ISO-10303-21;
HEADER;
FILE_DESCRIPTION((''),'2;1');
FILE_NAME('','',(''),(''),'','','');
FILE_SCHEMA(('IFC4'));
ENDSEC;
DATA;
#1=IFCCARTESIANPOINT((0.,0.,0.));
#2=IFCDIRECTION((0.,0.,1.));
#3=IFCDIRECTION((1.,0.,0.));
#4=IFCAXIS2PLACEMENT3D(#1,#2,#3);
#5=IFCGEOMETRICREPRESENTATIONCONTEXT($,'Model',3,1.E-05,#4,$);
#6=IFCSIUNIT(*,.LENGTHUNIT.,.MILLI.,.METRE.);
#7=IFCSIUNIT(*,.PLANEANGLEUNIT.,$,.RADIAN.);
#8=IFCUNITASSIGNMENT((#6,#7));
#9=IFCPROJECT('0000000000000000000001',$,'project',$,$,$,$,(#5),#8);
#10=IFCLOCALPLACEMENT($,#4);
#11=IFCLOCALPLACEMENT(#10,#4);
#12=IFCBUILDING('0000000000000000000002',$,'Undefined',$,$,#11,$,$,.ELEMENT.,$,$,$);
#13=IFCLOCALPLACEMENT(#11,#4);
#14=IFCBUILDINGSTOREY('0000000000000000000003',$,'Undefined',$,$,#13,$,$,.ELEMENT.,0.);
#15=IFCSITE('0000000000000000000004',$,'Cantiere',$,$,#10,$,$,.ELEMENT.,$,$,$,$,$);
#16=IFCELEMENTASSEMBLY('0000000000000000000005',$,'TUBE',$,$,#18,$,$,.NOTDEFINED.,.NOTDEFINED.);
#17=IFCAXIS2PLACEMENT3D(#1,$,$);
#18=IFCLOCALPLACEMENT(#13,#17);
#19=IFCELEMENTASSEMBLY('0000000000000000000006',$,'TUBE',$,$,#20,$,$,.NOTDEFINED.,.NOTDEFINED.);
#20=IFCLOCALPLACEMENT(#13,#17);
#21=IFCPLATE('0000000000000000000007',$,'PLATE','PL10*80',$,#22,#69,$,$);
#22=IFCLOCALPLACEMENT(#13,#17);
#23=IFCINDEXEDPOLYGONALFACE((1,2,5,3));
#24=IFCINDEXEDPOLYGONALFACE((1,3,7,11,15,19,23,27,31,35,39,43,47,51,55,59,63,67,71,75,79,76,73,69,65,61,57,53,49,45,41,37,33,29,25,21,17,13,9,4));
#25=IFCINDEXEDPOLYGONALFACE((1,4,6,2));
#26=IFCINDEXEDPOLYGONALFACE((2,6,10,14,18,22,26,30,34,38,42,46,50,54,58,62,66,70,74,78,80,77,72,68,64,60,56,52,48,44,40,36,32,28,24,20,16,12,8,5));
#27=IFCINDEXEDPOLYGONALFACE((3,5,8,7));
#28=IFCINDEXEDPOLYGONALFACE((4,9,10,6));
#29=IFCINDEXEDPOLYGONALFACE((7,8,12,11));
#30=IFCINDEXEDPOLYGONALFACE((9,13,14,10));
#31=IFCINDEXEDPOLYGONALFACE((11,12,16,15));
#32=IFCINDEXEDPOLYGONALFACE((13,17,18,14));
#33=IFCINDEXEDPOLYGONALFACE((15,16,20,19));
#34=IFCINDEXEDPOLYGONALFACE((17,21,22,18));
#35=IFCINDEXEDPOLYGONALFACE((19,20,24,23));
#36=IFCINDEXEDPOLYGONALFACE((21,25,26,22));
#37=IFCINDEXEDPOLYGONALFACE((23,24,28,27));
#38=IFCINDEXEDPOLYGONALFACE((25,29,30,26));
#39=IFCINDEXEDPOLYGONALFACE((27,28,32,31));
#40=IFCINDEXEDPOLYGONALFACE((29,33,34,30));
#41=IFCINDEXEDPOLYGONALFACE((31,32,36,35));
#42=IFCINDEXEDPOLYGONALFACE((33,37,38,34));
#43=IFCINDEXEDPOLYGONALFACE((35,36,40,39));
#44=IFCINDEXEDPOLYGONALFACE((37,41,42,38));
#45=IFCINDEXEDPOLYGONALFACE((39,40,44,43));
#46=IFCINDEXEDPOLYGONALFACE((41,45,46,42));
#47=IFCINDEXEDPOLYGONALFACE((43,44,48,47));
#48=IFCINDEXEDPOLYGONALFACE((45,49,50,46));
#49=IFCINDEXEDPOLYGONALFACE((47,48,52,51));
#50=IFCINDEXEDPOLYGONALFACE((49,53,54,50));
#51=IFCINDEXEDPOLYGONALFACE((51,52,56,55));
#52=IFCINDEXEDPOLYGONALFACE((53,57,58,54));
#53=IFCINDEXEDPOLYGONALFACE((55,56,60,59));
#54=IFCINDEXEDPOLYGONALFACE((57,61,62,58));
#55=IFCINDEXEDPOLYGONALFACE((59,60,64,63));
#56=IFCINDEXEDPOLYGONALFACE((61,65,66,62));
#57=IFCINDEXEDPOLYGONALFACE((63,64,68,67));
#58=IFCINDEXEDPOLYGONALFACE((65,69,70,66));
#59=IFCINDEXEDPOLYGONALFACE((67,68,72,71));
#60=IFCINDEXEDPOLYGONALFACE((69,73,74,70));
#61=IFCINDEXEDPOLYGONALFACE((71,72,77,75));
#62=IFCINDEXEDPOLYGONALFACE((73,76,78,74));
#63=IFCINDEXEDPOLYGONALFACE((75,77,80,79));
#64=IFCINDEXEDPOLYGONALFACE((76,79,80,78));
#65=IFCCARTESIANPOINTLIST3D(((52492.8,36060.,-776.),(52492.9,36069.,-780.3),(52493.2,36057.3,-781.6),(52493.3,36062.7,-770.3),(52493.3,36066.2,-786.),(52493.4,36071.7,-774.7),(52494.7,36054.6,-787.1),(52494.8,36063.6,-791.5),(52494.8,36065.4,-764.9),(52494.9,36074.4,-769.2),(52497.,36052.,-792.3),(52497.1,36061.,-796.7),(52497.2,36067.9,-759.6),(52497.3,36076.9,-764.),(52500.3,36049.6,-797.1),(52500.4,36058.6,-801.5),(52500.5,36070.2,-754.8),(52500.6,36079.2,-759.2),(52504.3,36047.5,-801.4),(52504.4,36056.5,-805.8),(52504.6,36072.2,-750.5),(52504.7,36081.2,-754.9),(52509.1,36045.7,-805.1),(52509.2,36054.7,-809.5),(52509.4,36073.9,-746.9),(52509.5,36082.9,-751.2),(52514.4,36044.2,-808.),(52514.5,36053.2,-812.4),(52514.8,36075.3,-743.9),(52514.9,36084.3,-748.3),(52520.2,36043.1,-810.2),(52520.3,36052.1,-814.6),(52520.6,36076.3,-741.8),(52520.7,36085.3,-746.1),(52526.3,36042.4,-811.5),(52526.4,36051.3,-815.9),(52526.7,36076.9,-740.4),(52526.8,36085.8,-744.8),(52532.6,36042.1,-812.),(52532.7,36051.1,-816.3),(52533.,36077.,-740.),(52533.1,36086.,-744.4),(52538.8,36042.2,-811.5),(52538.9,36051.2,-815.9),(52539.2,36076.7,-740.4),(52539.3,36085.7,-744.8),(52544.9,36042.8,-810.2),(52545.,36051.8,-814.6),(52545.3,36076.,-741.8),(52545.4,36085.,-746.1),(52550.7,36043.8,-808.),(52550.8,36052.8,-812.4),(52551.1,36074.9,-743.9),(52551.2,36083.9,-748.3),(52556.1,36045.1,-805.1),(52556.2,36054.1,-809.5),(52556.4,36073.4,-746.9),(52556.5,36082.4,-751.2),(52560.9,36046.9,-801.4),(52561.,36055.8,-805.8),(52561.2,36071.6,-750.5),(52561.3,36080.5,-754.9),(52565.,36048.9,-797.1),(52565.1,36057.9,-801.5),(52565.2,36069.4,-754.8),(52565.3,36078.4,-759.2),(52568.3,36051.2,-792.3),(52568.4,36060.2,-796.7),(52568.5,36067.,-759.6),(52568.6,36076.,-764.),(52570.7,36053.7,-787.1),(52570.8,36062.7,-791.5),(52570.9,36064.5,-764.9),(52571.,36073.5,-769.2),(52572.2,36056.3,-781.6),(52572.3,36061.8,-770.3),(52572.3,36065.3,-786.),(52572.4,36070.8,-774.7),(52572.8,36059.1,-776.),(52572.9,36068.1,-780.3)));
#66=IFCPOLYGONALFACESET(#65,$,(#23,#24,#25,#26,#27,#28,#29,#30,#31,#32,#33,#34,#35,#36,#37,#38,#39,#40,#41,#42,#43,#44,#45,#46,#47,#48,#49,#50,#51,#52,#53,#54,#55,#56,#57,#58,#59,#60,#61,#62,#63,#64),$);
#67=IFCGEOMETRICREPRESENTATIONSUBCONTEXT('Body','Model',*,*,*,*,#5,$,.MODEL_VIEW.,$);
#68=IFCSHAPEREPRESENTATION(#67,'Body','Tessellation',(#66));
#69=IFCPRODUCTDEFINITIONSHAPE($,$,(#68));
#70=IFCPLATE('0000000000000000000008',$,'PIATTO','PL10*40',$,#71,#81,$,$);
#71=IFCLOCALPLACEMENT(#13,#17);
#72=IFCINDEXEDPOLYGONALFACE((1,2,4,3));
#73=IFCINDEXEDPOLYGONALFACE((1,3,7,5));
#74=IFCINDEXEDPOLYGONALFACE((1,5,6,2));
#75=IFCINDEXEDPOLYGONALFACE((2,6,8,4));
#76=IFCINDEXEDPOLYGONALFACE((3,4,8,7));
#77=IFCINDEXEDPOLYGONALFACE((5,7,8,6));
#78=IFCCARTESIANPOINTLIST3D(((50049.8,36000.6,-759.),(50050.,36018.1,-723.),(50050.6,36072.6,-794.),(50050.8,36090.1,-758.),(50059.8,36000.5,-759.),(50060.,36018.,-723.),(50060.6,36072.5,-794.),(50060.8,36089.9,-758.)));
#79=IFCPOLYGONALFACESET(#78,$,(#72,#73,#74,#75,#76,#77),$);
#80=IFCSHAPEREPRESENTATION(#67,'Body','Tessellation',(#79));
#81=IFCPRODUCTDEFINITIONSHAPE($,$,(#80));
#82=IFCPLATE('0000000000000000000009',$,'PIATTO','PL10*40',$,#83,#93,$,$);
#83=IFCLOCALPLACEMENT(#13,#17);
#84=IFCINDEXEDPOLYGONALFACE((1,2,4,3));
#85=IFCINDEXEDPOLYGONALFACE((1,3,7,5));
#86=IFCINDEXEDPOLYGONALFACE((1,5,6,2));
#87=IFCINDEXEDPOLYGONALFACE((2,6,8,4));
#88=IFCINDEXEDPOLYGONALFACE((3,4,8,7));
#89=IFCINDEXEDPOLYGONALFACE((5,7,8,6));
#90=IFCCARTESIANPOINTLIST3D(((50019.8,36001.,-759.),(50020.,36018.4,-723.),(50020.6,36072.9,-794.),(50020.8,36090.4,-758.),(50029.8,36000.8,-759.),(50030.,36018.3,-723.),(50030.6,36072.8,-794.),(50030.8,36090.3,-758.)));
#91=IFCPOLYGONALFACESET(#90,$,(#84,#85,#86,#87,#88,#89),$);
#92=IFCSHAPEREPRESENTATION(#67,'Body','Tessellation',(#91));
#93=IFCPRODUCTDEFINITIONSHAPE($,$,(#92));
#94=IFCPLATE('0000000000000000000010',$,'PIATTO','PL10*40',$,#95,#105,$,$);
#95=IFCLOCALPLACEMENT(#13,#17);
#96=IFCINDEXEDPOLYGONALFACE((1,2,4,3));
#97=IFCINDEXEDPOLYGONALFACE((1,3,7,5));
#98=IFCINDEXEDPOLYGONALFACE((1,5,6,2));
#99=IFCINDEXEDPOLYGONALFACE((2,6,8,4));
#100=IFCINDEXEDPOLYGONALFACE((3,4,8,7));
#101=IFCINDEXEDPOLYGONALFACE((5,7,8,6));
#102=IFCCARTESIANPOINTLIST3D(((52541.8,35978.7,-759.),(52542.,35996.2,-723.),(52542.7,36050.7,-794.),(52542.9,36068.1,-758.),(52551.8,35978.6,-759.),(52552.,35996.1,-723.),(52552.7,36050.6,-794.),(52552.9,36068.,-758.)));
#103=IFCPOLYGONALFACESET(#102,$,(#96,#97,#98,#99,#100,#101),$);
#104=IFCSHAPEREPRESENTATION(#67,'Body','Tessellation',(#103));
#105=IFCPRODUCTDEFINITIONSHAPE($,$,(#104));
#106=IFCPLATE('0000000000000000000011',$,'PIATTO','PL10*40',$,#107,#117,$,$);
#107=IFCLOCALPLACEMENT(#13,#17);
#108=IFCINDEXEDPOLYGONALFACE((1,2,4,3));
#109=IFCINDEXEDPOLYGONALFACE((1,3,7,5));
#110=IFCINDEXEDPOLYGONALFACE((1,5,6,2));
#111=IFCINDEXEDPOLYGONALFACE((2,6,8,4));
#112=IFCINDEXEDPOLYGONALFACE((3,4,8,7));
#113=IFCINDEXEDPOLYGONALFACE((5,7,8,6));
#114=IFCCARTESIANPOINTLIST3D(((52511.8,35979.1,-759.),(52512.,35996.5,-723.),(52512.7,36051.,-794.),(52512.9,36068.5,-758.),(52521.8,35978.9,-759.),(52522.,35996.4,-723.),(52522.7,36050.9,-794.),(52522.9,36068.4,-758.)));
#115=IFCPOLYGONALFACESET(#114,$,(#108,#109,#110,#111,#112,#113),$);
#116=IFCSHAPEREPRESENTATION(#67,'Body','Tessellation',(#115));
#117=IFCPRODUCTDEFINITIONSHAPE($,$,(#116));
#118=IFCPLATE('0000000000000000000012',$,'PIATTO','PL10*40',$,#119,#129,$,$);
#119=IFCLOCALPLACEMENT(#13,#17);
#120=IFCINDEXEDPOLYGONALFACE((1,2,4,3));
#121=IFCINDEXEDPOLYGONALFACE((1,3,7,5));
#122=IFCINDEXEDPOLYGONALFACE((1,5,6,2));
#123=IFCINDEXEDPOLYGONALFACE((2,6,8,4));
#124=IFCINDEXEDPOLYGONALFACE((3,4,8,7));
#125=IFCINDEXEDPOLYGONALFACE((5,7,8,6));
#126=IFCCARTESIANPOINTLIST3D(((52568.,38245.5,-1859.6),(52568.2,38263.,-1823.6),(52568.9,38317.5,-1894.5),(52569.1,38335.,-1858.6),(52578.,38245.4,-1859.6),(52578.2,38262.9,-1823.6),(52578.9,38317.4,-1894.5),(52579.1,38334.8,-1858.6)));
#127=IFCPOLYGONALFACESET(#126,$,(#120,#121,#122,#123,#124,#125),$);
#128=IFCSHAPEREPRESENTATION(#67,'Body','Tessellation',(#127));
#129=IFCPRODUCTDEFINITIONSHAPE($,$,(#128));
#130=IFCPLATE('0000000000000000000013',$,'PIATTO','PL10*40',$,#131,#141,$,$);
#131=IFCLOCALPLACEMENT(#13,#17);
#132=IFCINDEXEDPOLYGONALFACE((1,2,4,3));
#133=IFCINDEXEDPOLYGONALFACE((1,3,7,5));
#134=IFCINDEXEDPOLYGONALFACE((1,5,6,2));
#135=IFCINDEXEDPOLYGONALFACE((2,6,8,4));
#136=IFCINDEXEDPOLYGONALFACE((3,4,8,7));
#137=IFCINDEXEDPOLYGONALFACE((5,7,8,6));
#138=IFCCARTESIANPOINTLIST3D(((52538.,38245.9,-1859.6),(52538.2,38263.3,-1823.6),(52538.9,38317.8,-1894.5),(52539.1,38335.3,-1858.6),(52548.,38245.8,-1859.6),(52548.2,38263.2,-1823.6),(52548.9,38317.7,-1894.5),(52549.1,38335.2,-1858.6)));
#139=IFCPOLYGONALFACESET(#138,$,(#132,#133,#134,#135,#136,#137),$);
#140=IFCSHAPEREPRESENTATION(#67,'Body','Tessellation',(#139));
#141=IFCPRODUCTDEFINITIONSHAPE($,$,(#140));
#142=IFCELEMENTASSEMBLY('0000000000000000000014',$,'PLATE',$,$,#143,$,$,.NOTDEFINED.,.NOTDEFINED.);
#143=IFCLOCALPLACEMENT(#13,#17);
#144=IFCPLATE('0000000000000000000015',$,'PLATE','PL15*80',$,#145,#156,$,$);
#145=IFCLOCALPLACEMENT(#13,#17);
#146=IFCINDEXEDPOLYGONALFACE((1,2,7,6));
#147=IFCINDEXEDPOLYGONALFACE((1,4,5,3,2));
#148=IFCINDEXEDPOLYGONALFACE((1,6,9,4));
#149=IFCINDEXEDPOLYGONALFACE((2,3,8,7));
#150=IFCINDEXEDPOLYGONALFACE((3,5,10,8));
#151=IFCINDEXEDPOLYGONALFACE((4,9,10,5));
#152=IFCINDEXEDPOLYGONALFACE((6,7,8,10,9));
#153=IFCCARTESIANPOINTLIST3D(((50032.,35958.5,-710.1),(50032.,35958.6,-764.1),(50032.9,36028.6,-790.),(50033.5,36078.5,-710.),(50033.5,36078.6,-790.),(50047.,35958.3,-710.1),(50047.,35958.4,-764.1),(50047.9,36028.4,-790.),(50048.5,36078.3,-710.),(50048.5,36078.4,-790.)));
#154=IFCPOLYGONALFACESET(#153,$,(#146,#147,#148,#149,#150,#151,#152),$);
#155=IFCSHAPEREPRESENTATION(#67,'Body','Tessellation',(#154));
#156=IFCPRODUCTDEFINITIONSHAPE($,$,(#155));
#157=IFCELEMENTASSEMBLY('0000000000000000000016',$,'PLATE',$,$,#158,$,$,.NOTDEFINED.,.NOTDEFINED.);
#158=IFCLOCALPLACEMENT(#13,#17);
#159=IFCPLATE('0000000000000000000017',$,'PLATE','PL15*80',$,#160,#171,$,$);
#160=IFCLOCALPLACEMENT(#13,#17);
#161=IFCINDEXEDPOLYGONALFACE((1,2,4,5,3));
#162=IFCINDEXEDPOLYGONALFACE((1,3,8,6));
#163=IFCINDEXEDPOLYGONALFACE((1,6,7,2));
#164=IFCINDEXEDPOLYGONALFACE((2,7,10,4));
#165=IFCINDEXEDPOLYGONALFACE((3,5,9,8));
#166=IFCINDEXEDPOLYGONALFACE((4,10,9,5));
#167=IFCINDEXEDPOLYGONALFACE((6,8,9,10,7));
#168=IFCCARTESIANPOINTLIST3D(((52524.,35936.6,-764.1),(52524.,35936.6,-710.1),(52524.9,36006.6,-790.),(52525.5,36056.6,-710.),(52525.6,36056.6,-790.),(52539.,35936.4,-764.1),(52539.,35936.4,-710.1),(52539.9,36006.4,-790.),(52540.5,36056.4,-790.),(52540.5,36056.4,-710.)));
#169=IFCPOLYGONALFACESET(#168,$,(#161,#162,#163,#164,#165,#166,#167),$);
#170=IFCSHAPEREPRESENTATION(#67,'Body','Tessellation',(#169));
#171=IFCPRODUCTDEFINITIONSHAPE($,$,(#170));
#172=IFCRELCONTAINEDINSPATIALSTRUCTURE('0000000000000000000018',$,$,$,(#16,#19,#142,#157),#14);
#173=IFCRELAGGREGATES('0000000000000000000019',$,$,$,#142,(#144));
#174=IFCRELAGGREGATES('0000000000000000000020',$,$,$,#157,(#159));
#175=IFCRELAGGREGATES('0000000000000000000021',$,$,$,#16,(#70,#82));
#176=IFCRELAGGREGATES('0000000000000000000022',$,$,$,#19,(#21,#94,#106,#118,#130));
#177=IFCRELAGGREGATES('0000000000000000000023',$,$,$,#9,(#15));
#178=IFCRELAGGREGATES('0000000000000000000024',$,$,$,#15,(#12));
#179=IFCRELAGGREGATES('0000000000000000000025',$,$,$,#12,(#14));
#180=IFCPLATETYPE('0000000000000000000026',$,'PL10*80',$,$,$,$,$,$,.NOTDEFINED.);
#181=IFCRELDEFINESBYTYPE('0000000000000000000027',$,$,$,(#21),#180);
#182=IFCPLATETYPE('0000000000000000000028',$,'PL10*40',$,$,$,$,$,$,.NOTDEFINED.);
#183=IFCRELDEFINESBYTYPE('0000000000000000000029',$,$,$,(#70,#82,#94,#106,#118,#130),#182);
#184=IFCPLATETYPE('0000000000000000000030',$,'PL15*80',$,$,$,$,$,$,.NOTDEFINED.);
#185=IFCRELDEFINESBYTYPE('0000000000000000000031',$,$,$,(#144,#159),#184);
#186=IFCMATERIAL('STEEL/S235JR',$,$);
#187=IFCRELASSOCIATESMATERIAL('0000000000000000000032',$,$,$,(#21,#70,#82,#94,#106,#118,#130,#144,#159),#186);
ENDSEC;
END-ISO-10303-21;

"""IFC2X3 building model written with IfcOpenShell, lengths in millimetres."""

from ifc_helpers import new_model, si_unit, frame, origin_with_axes, place, context, subcontext, project, spatial, polyline, outline, extrude, material, type_object, element, aggregate, save


model = new_model("IFC2X3")

# Units and contexts
model_context = context("Model", 3, precision=1e-05, world=origin_with_axes())
body_context = subcontext(model_context, "Body", "Model", "MODEL_VIEW")
ifc_project = project(units=[si_unit("LENGTHUNIT", "METRE", prefix="MILLI"), si_unit("PLANEANGLEUNIT", "RADIAN")], contexts=[model_context])

# Site, building, storey
site_placement = place(None, origin_with_axes())
site = spatial("IfcSite", under=ifc_project, at=site_placement, Name="Cantiere", CompositionType="ELEMENT")
building_placement = place(site_placement, origin_with_axes())
building = spatial("IfcBuilding", under=site, at=building_placement, Name="Undefined", CompositionType="ELEMENT")
storey_placement = place(building_placement, origin_with_axes())
storey = spatial("IfcBuildingStorey", under=building, at=storey_placement, Name="Undefined", CompositionType="ELEMENT", Elevation=0.0)

# Shared definitions
ifc_material_1 = material(Name="STEEL/S235JR")

# Element assemblies, plate
assembly_1_placement = place(storey_placement, origin_with_axes())
assembly_1 = element("IfcElementAssembly", 1, at=assembly_1_placement, inside=storey, Name="TUBE", AssemblyPlace="NOTDEFINED", PredefinedType="NOTDEFINED")
plate_type_1 = type_object("IfcPlateType", Name="PL10*80", PredefinedType="NOTDEFINED")
assembly_2_placement = place(storey_placement, origin_with_axes())
assembly_2 = element("IfcElementAssembly", 2, at=assembly_2_placement, inside=storey, Name="TUBE", AssemblyPlace="NOTDEFINED", PredefinedType="NOTDEFINED")
plate_1_placement = place(assembly_2_placement, frame((52493.0, 36082.0, -742.2), z_axis=(-0.010393, -0.899564, 0.436666), x_axis=(-0.005052, -0.436637, -0.899624)))
plate_1 = element("IfcPlate", 3, at=plate_1_placement, type_object=plate_type_1, material=ifc_material_1, Name="PLATE", Description="PL10*80", context=body_context, shape_type="SweptSolid", body=[
    extrude(outline(polyline([(0.0, 40.0), (0.5, 33.7), (2.0, 27.6), (4.4, 21.8), (7.6, 16.5), (11.7, 11.7), (16.5, 7.6), (21.8, 4.4), (27.6, 2.0), (33.7, 0.5), (40.0, 0.0), (40.0, 0.0), (46.3, 0.5), (52.4, 2.0), (58.2, 4.4), (63.5, 7.6), (68.3, 11.7), (72.4, 16.5), (75.6, 21.8), (78.0, 27.6), (79.5, 33.7), (80.0, 40.0), (80.0, 40.0), (79.5, 46.3), (78.0, 52.4), (75.6, 58.2), (72.4, 63.5), (68.3, 68.3), (63.5, 72.4), (58.2, 75.6), (52.4, 78.0), (46.3, 79.5), (40.0, 80.0), (40.0, 80.0), (33.7, 79.5), (27.6, 78.0), (21.8, 75.6), (16.5, 72.4), (11.7, 68.3), (7.6, 63.5), (4.4, 58.2), (2.0, 52.4), (0.5, 46.3), (0.0, 40.0), (0.0, 40.0)])), frame((0.0, 0.0, -5.0), z_axis=(0.0, 0.0, 1.0), x_axis=(1.0, 0.0, 0.0)), (0.0, 0.0, 1.0), 10.0),
])

# Plates
plate_type_2 = type_object("IfcPlateType", Name="PL10*40", PredefinedType="NOTDEFINED")
plate_2_placement = place(assembly_1_placement, frame((50055.6, 36072.5, -794.0), z_axis=(-0.999939, 0.011001, 0.000006), x_axis=(-0.009893, -0.899493, 0.436823)))
plate_2 = element("IfcPlate", 4, at=plate_2_placement, type_object=plate_type_2, material=ifc_material_1, Name="PIATTO", Description="PL10*40", context=body_context, shape_type="SweptSolid", body=[
    extrude(outline(polyline([(0.0, 0.0), (80.0, 0.0), (80.0, 40.0), (0.0, 40.0), (0.0, 0.0)])), frame((0.0, 0.0, -5.0), z_axis=(0.0, 0.0, 1.0), x_axis=(1.0, 0.0, 0.0)), (0.0, 0.0, 1.0), 10.0),
])
plate_3_placement = place(assembly_1_placement, frame((50025.6, 36072.9, -794.0), z_axis=(-0.999939, 0.011001, 0.000006), x_axis=(-0.009893, -0.899493, 0.436823)))
plate_3 = element("IfcPlate", 5, at=plate_3_placement, type_object=plate_type_2, material=ifc_material_1, Name="PIATTO", Description="PL10*40", context=body_context, shape_type="SweptSolid", body=[
    extrude(outline(polyline([(0.0, 0.0), (80.0, 0.0), (80.0, 40.0), (0.0, 40.0), (0.0, 0.0)])), frame((0.0, 0.0, -5.0), z_axis=(0.0, 0.0, 1.0), x_axis=(1.0, 0.0, 0.0)), (0.0, 0.0, 1.0), 10.0),
])
plate_4_placement = place(assembly_2_placement, frame((52547.7, 36050.6, -794.0), z_axis=(-0.999933, 0.011556, 0.000006), x_axis=(-0.010393, -0.899564, 0.436666)))
plate_4 = element("IfcPlate", 6, at=plate_4_placement, type_object=plate_type_2, material=ifc_material_1, Name="PIATTO", Description="PL10*40", context=body_context, shape_type="SweptSolid", body=[
    extrude(outline(polyline([(0.0, 0.0), (80.0, 0.0), (80.0, 40.0), (0.0, 40.0), (0.0, 0.0)])), frame((0.0, 0.0, -5.0), z_axis=(0.0, 0.0, 1.0), x_axis=(1.0, 0.0, 0.0)), (0.0, 0.0, 1.0), 10.0),
])
plate_5_placement = place(assembly_2_placement, frame((52517.7, 36051.0, -794.0), z_axis=(-0.999933, 0.011556, 0.000006), x_axis=(-0.010393, -0.899564, 0.436666)))
plate_5 = element("IfcPlate", 7, at=plate_5_placement, type_object=plate_type_2, material=ifc_material_1, Name="PIATTO", Description="PL10*40", context=body_context, shape_type="SweptSolid", body=[
    extrude(outline(polyline([(0.0, 0.0), (80.0, 0.0), (80.0, 40.0), (0.0, 40.0), (0.0, 0.0)])), frame((0.0, 0.0, -5.0), z_axis=(0.0, 0.0, 1.0), x_axis=(1.0, 0.0, 0.0)), (0.0, 0.0, 1.0), 10.0),
])
plate_6_placement = place(assembly_2_placement, frame((52573.0, 38245.5, -1859.6), z_axis=(0.999933, -0.011562, -0.000003), x_axis=(0.010399, 0.899498, -0.436802)))
plate_6 = element("IfcPlate", 8, at=plate_6_placement, type_object=plate_type_2, material=ifc_material_1, Name="PIATTO", Description="PL10*40", context=body_context, shape_type="SweptSolid", body=[
    extrude(outline(polyline([(0.0, 0.0), (80.0, 0.0), (80.0, 40.0), (0.0, 40.0), (0.0, 0.0)])), frame((0.0, 0.0, -5.0), z_axis=(0.0, 0.0, 1.0), x_axis=(1.0, 0.0, 0.0)), (0.0, 0.0, 1.0), 10.0),
])
plate_7_placement = place(assembly_2_placement, frame((52543.0, 38245.8, -1859.6), z_axis=(0.999933, -0.011562, -0.000003), x_axis=(0.010399, 0.899498, -0.436802)))
plate_7 = element("IfcPlate", 9, at=plate_7_placement, type_object=plate_type_2, material=ifc_material_1, Name="PIATTO", Description="PL10*40", context=body_context, shape_type="SweptSolid", body=[
    extrude(outline(polyline([(0.0, 0.0), (80.0, 0.0), (80.0, 40.0), (0.0, 40.0), (0.0, 0.0)])), frame((0.0, 0.0, -5.0), z_axis=(0.0, 0.0, 1.0), x_axis=(1.0, 0.0, 0.0)), (0.0, 0.0, 1.0), 10.0),
])

# Element assemblies, plates
assembly_3_placement = place(storey_placement, origin_with_axes())
assembly_3 = element("IfcElementAssembly", 10, at=assembly_3_placement, inside=storey, Name="PLATE", AssemblyPlace="NOTDEFINED", PredefinedType="NOTDEFINED")
plate_type_3 = type_object("IfcPlateType", Name="PL15*80", PredefinedType="NOTDEFINED")
plate_8_placement = place(assembly_3_placement, frame((50041.0, 36078.4, -710.0), z_axis=(0.999922, -0.012472, -0.000001), x_axis=(-0.012472, -0.999922, -0.000764)))
plate_8 = element("IfcPlate", 11, at=plate_8_placement, type_object=plate_type_3, material=ifc_material_1, Name="PLATE", Description="PL15*80", context=body_context, shape_type="SweptSolid", body=[
    extrude(outline(polyline([(0.0, 0.0), (120.0, 0.0), (120.0, 54.0), (50.0, 80.0), (0.0, 80.0), (0.0, 0.0)])), frame((0.0, 0.0, -7.5), z_axis=(0.0, 0.0, 1.0), x_axis=(1.0, 0.0, 0.0)), (0.0, 0.0, 1.0), 15.0),
])
aggregate(assembly_3, [plate_8])
assembly_4_placement = place(storey_placement, origin_with_axes())
assembly_4 = element("IfcElementAssembly", 12, at=assembly_4_placement, inside=storey, Name="PLATE", AssemblyPlace="NOTDEFINED", PredefinedType="NOTDEFINED")
plate_9_placement = place(assembly_4_placement, frame((52533.0, 36056.5, -710.0), z_axis=(0.999915, -0.013026, -0.000001), x_axis=(-0.013026, -0.999915, -0.000764)))
plate_9 = element("IfcPlate", 13, at=plate_9_placement, type_object=plate_type_3, material=ifc_material_1, Name="PLATE", Description="PL15*80", context=body_context, shape_type="SweptSolid", body=[
    extrude(outline(polyline([(0.0, 0.0), (120.0, 0.0), (120.0, 54.0), (50.0, 80.0), (0.0, 80.0), (0.0, 0.0)])), frame((0.0, 0.0, -7.5), z_axis=(0.0, 0.0, 1.0), x_axis=(1.0, 0.0, 0.0)), (0.0, 0.0, 1.0), 15.0),
])
aggregate(assembly_4, [plate_9])

aggregate(assembly_1, [plate_2, plate_3])
aggregate(assembly_2, [plate_1, plate_4, plate_5, plate_6, plate_7])

save(model, "model.ifc")
